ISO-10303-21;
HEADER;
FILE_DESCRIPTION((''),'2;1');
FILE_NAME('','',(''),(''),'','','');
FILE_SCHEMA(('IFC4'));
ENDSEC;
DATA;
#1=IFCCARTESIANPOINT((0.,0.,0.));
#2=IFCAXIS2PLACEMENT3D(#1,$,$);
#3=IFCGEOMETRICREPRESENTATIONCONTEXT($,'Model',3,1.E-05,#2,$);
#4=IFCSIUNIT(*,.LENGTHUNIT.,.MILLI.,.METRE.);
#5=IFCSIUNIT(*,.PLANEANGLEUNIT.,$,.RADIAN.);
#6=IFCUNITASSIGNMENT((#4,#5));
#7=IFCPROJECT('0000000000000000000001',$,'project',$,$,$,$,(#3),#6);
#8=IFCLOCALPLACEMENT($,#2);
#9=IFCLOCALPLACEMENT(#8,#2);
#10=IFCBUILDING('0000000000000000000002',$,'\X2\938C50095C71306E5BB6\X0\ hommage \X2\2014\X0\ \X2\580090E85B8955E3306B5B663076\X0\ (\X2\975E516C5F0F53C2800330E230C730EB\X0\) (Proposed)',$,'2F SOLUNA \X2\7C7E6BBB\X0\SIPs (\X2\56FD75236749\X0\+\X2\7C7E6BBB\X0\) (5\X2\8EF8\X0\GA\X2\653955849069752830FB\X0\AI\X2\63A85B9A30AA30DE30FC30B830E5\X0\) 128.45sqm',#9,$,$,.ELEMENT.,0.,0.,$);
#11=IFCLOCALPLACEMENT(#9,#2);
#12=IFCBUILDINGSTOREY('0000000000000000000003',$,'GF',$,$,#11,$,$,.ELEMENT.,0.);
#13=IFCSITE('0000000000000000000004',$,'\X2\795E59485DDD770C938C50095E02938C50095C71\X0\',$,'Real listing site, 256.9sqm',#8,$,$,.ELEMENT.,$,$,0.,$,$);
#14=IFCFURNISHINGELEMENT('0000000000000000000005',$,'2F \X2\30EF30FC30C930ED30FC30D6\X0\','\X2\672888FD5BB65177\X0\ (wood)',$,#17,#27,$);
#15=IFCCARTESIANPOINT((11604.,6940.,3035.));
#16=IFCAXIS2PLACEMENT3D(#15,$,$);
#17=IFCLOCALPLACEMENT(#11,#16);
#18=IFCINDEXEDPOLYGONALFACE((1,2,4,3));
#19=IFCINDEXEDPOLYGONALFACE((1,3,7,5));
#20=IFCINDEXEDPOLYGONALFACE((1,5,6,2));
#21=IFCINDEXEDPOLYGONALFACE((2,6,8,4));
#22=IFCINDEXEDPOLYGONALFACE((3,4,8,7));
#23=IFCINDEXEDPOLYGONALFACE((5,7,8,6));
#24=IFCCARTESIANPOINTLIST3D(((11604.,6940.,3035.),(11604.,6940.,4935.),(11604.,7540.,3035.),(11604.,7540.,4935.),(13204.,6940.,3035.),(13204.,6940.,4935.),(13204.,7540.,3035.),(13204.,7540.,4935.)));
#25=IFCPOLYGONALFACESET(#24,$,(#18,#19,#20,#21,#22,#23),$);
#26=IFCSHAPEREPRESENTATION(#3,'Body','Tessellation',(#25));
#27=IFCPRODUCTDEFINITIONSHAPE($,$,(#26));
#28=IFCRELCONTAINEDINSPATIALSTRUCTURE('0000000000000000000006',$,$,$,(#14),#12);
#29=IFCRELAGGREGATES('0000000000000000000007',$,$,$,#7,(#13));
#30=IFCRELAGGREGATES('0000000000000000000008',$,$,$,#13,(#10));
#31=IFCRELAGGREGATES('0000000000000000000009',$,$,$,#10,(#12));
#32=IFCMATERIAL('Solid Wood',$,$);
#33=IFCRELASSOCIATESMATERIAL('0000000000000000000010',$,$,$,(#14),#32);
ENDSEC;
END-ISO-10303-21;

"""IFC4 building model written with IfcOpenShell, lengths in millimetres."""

from ifc_helpers import new_model, si_unit, frame, frame_2d, origin, place, context, project, spatial, rectangle, extrude, material, element, save


model = new_model("IFC4")

# Units and contexts
model_context = context("Model", 3, precision=1e-05, world=origin())
ifc_project = project(units=[si_unit("LENGTHUNIT", "METRE", prefix="MILLI"), si_unit("PLANEANGLEUNIT", "RADIAN")], contexts=[model_context])

# Site, building, storey
site_placement = place(None, origin())
site = spatial("IfcSite", under=ifc_project, at=site_placement, Name="神奈川県鎌倉市鎌倉山", ObjectType="Real listing site, 256.9sqm", CompositionType="ELEMENT", RefElevation=0.0)
building_placement = place(site_placement, origin())
building = spatial("IfcBuilding", under=site, at=building_placement, Name="鎌倉山の家 hommage — 堀部安嗣に学ぶ (非公式参考モデル) (Proposed)", ObjectType="2F SOLUNA 籾殻SIPs (国産杉+籾殻) (5軸GA改善適用・AI推定オマージュ) 128.45sqm", CompositionType="ELEMENT", ElevationOfRefHeight=0.0, ElevationOfTerrain=0.0)
storey_placement = place(building_placement, origin())
storey = spatial("IfcBuildingStorey", under=building, at=storey_placement, Name="GF", CompositionType="ELEMENT", Elevation=0.0)

# Shared definitions
ifc_material_1 = material(Name="Solid Wood")

# Furnishing element
furnishing_1_placement = place(storey_placement, frame((11604.0, 6940.0, 3035.0)))
element("IfcFurnishingElement", 1, at=furnishing_1_placement, inside=storey, material=ifc_material_1, Name="2F ワードローブ", Description="木製家具 (wood)", context=model_context, shape_type="SweptSolid", body=[
    extrude(rectangle(XDim=1600.0, YDim=600.0, at=frame_2d((800.0, 300.0))), frame((11604.0, 6940.0, 3035.0)), (0.0, 0.0, 1.0), 1900.0),
])

save(model, "model.ifc")
